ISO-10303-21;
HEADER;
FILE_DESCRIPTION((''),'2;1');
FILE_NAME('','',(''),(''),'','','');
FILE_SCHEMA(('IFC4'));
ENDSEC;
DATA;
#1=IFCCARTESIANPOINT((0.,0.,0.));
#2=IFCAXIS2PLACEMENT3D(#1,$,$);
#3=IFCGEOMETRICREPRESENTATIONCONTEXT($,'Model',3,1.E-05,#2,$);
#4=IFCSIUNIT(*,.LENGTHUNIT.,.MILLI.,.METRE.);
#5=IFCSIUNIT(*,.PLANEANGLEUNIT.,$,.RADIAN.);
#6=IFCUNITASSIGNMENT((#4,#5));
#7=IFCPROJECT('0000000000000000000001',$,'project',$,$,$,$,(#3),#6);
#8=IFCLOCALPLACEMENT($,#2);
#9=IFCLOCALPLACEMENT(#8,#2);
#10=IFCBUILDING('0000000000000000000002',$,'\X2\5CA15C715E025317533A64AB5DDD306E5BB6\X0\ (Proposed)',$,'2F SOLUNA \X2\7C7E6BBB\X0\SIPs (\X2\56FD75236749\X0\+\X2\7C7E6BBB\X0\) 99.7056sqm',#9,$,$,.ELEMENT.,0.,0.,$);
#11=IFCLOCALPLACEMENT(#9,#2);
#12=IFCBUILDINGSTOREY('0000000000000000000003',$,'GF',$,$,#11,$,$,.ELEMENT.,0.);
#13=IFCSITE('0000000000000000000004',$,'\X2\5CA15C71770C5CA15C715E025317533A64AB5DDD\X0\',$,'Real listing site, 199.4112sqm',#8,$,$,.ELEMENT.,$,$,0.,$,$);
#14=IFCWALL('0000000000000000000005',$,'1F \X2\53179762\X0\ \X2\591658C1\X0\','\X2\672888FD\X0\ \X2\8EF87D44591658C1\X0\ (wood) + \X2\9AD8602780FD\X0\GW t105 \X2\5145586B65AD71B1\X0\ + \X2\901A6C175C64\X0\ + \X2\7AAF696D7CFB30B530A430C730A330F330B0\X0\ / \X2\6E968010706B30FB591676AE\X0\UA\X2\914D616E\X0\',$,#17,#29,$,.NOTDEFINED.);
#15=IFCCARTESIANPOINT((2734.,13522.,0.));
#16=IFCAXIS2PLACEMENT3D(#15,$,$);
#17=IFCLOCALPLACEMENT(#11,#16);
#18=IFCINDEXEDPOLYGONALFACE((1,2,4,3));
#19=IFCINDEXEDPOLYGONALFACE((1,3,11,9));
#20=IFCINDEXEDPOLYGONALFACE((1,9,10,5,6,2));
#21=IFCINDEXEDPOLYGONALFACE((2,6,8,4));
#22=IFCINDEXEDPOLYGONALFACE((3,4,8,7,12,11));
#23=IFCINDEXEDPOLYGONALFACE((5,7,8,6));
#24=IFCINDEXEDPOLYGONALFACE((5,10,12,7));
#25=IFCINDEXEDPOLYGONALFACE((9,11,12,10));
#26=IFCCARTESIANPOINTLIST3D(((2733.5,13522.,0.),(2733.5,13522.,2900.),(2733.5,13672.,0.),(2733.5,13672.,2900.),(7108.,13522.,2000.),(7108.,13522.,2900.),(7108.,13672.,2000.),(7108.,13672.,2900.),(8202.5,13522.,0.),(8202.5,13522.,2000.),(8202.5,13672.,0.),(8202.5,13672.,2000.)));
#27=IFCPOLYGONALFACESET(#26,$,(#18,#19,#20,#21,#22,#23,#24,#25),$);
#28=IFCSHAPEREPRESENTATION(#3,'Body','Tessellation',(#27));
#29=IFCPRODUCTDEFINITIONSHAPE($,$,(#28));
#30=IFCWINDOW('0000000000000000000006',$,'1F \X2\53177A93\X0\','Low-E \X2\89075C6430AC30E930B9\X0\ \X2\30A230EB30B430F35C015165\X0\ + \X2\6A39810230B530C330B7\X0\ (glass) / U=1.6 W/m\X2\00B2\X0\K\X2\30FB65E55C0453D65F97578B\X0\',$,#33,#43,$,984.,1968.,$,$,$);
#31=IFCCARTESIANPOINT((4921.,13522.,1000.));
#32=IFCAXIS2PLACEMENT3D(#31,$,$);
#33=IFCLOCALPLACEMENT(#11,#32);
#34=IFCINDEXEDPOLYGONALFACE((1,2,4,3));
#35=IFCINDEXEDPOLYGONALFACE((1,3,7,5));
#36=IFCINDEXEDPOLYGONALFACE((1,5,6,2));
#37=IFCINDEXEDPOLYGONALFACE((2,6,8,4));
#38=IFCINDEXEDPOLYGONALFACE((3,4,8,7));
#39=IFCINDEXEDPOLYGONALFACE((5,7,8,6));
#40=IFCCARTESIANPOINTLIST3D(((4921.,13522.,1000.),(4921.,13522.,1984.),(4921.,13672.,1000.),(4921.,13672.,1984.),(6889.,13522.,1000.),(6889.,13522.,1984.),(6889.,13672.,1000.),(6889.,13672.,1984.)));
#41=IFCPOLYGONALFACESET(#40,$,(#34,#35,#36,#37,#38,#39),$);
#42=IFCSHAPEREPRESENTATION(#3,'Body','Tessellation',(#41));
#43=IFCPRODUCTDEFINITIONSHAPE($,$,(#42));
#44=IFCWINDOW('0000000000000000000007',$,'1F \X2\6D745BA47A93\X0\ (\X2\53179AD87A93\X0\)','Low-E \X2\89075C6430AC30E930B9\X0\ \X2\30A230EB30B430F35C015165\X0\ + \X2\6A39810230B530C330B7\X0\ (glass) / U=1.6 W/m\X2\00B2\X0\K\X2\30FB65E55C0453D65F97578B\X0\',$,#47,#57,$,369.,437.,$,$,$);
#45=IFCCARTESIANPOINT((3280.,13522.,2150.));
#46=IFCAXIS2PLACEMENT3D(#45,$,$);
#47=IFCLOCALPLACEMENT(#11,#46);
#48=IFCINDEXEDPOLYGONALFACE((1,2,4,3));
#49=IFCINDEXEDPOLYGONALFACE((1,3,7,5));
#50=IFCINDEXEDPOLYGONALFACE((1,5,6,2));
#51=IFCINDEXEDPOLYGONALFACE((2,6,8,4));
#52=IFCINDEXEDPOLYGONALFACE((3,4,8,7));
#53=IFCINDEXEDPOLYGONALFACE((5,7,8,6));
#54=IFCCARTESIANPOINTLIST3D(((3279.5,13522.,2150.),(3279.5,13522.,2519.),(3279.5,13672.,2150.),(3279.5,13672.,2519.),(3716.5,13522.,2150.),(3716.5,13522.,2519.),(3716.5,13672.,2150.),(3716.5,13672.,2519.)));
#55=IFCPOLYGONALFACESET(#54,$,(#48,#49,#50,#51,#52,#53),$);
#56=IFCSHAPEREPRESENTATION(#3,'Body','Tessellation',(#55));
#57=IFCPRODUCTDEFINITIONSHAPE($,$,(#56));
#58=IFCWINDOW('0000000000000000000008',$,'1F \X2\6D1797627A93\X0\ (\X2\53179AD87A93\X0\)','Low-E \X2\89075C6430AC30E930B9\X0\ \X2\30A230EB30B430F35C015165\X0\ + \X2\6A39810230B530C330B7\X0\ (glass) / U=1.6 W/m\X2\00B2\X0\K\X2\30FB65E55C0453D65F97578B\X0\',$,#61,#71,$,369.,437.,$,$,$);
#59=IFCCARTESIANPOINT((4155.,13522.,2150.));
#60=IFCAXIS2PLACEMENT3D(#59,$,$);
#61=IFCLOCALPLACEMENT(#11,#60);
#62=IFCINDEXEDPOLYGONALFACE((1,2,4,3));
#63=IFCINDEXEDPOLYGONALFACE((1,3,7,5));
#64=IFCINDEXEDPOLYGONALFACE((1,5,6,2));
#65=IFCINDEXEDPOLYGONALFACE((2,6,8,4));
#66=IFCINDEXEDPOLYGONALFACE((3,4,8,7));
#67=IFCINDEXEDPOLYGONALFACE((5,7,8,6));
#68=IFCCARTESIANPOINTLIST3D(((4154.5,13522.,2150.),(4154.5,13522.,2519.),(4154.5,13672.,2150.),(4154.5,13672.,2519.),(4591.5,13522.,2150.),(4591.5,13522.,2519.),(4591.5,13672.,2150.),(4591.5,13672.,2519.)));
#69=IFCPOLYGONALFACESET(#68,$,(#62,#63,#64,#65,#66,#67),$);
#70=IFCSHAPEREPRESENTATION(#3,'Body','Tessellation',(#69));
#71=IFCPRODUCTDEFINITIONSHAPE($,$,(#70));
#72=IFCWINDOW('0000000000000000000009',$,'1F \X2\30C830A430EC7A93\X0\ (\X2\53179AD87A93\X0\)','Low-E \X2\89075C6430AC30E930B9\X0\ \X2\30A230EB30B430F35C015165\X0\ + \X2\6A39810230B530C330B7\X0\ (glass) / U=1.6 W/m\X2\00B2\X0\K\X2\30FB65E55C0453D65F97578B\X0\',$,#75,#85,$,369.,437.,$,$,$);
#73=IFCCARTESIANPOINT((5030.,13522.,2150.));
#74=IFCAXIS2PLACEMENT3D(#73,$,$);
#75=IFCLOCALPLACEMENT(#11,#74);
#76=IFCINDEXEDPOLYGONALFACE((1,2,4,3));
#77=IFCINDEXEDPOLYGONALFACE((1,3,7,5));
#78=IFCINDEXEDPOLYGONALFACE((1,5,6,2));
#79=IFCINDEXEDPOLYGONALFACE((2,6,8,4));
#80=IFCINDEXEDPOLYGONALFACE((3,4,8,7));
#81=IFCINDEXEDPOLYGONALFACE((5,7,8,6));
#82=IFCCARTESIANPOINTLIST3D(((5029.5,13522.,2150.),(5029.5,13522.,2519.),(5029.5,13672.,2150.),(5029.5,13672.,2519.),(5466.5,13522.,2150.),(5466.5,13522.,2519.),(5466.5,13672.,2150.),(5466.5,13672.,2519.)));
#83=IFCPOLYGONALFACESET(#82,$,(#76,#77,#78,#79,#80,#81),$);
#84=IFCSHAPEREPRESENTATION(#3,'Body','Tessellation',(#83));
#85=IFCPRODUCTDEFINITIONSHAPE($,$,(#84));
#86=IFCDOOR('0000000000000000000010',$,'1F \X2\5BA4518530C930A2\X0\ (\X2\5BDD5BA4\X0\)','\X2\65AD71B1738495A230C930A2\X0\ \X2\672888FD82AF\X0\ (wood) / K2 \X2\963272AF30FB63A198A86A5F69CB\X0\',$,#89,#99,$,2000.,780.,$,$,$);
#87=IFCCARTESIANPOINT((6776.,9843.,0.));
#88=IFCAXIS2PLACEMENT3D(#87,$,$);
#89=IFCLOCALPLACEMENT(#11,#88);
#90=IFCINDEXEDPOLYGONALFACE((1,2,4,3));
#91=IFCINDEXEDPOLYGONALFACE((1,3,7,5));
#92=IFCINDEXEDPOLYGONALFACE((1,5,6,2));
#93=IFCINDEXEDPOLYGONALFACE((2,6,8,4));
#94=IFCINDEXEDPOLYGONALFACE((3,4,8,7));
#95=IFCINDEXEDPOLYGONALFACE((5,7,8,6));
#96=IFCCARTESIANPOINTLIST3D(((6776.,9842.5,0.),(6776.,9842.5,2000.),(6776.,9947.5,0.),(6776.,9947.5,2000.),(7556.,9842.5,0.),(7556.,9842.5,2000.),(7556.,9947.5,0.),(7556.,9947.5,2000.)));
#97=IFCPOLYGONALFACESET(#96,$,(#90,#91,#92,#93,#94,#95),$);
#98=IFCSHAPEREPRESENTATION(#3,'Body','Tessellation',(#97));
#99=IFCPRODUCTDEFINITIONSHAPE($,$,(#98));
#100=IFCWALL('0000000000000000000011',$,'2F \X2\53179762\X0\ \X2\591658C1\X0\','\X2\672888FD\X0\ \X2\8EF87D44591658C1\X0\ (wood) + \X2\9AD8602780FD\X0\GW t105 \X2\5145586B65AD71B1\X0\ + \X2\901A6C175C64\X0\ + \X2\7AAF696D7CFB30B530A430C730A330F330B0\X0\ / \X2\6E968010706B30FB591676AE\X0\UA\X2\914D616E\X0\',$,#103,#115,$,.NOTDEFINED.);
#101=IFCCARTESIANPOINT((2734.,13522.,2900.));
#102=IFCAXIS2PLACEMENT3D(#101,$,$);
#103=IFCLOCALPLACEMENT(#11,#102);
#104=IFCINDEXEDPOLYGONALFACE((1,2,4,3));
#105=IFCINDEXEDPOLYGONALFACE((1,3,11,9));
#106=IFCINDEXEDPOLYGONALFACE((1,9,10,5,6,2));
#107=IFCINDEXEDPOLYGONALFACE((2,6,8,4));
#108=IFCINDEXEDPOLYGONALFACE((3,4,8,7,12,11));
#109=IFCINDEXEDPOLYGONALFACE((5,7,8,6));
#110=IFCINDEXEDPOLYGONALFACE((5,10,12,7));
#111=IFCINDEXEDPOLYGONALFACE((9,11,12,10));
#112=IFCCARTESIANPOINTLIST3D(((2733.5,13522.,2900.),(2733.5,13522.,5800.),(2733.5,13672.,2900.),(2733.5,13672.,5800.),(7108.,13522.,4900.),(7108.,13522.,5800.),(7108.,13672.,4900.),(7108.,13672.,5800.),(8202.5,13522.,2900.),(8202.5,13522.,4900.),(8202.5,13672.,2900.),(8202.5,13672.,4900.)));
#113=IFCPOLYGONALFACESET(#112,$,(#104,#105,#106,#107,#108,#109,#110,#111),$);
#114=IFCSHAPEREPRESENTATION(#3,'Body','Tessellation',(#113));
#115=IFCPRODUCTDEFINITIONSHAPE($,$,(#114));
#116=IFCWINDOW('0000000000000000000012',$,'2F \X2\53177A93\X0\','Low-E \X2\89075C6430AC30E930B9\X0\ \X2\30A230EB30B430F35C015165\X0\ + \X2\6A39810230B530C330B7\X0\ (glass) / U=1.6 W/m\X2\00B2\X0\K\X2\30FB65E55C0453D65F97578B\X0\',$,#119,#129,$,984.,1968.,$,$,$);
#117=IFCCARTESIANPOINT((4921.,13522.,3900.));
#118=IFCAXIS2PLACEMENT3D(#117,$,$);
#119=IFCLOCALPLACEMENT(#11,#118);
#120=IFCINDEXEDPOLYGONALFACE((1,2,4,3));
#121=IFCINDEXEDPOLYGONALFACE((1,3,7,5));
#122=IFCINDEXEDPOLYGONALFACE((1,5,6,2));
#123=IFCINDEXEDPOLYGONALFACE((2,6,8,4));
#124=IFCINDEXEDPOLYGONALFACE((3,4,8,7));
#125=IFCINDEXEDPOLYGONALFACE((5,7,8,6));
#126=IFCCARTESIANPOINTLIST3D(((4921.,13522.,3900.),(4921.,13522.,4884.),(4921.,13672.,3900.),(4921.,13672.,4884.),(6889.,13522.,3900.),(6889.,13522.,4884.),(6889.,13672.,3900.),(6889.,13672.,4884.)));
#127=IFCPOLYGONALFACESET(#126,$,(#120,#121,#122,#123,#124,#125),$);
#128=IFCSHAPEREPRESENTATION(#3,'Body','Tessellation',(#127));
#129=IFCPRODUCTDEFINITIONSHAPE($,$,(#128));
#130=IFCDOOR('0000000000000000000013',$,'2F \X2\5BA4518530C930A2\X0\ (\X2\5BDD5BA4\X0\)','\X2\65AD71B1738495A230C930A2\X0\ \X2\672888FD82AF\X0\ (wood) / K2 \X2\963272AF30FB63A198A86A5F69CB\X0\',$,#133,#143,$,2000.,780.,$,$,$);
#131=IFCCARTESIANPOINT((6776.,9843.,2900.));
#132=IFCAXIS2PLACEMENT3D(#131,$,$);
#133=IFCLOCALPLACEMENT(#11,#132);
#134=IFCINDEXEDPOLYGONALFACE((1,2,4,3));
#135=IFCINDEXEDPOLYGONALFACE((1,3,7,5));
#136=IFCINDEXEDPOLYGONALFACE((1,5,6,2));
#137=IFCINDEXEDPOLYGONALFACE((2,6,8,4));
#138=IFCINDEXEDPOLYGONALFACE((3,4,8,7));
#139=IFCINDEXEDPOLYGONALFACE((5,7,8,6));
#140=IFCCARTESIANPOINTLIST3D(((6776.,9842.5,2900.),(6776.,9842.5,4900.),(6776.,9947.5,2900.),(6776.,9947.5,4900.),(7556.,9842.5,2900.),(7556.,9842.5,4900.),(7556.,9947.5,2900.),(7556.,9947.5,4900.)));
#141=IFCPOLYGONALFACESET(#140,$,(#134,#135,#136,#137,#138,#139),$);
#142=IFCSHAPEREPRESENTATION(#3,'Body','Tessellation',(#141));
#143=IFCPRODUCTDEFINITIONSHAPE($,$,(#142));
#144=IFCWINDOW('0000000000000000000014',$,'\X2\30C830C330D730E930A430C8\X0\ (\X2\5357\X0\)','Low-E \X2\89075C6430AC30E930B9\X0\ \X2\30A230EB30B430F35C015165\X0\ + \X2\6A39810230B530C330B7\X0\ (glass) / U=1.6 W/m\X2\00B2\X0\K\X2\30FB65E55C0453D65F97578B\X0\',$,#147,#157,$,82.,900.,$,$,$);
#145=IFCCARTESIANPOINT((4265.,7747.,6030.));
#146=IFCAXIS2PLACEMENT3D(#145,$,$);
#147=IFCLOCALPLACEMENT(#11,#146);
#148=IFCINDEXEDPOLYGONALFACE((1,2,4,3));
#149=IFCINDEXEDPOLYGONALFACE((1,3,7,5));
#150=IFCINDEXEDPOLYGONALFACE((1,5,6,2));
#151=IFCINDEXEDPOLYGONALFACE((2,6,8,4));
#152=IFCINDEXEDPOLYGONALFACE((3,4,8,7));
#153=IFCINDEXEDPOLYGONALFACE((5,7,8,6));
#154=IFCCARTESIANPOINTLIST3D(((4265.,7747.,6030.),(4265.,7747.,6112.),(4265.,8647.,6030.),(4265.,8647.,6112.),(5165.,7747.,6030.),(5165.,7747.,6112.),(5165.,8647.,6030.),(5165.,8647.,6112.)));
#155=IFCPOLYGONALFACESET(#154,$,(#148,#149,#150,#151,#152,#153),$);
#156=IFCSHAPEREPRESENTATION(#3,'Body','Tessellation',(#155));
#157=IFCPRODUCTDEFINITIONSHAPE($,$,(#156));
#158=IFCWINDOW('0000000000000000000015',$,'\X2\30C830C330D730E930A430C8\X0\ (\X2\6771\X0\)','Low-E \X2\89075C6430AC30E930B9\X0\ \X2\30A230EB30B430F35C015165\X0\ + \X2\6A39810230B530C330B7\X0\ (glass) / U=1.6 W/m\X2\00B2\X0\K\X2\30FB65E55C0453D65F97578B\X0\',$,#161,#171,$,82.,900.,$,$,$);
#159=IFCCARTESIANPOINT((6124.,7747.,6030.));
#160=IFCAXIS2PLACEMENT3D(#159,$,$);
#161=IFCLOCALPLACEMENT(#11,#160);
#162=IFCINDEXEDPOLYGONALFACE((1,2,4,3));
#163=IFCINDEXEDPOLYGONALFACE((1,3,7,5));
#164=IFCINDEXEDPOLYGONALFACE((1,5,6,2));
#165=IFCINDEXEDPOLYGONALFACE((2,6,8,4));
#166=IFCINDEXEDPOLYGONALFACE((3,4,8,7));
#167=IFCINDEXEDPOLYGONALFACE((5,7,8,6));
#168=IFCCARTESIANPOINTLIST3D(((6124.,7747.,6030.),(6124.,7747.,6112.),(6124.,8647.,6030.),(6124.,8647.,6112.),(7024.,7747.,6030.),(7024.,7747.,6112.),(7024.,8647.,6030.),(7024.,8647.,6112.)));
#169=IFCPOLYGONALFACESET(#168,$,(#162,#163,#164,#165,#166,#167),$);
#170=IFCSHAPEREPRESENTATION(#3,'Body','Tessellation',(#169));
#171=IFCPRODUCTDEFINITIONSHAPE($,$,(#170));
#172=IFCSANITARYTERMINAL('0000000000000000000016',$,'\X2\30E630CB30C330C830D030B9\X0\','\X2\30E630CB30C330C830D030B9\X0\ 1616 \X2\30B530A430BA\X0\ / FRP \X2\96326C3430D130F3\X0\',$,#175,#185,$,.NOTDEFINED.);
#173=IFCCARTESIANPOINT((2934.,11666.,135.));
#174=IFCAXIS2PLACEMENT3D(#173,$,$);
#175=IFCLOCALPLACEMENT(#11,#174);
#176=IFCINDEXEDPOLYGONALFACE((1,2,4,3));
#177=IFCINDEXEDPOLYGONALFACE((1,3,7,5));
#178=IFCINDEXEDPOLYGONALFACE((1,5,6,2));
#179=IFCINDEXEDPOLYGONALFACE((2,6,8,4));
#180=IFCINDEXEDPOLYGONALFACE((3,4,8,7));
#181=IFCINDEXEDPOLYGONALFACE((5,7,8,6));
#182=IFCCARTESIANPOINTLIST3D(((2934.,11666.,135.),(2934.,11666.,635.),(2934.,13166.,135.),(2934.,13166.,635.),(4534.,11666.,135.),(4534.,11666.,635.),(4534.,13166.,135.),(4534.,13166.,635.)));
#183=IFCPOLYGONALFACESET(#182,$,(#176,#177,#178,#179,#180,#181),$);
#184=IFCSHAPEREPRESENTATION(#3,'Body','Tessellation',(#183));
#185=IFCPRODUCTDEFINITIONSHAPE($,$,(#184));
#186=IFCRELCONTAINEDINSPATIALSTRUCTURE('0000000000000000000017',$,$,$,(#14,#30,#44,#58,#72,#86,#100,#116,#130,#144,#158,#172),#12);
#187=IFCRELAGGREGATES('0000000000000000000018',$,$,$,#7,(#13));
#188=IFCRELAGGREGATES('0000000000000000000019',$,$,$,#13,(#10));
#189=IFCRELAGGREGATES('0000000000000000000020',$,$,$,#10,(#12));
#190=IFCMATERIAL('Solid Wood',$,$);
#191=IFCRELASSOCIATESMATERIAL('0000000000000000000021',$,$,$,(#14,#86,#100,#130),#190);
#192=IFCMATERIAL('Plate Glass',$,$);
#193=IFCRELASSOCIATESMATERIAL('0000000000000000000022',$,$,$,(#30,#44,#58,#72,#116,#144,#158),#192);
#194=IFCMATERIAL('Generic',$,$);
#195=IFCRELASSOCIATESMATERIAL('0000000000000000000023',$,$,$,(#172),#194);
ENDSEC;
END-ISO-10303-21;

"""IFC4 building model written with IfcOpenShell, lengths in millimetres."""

from ifc_helpers import new_model, si_unit, frame, frame_2d, origin, place, context, project, spatial, rectangle, extrude, material, element, fill, save


model = new_model("IFC4")

# Units and contexts
model_context = context("Model", 3, precision=1e-05, world=origin())
ifc_project = project(units=[si_unit("LENGTHUNIT", "METRE", prefix="MILLI"), si_unit("PLANEANGLEUNIT", "RADIAN")], contexts=[model_context])

# Site, building, storey
site_placement = place(None, origin())
site = spatial("IfcSite", under=ifc_project, at=site_placement, Name="岡山県岡山市北区撫川", ObjectType="Real listing site, 199.4112sqm", CompositionType="ELEMENT", RefElevation=0.0)
building_placement = place(site_placement, origin())
building = spatial("IfcBuilding", under=site, at=building_placement, Name="岡山市北区撫川の家 (Proposed)", ObjectType="2F SOLUNA 籾殻SIPs (国産杉+籾殻) 99.7056sqm", CompositionType="ELEMENT", ElevationOfRefHeight=0.0, ElevationOfTerrain=0.0)
storey_placement = place(building_placement, origin())
storey = spatial("IfcBuildingStorey", under=building, at=storey_placement, Name="GF", CompositionType="ELEMENT", Elevation=0.0)

# Wall, openings, windows
ifc_material_1 = material(Name="Solid Wood")
wall_1_placement = place(storey_placement, frame((2734.0, 13522.0, 0.0)))
wall_1 = element("IfcWall", 1, at=wall_1_placement, inside=storey, material=ifc_material_1, Name="1F 北面 外壁", Description="木製 軸組外壁 (wood) + 高性能GW t105 充填断熱 + 通気層 + 窯業系サイディング / 準耐火・外皮UA配慮", PredefinedType="NOTDEFINED", context=model_context, shape_type="SweptSolid", body=[
    extrude(rectangle(XDim=5469.0, YDim=150.0, at=frame_2d((2734.0, 75.0))), frame((2734.0, 13522.0, 0.0)), (0.0, 0.0, 1.0), 2900.0),
])
opening_1_placement = place(storey_placement, frame((4921.0, 13522.0, 1000.0)))
opening_1 = element("IfcOpeningElement", 2, at=opening_1_placement, cuts=wall_1, PredefinedType="NOTDEFINED", context=model_context, shape_type="SweptSolid", body=[
    extrude(rectangle(XDim=1968.0, YDim=150.0, at=frame_2d((984.0, 75.0))), frame((4921.0, 13522.0, 1000.0)), (0.0, 0.0, 1.0), 984.0),
])
opening_2_placement = place(storey_placement, frame((3280.0, 13522.0, 2150.0)))
opening_2 = element("IfcOpeningElement", 3, at=opening_2_placement, cuts=wall_1, PredefinedType="NOTDEFINED", context=model_context, shape_type="SweptSolid", body=[
    extrude(rectangle(XDim=437.0, YDim=150.0, at=frame_2d((218.0, 75.0))), frame((3280.0, 13522.0, 2150.0)), (0.0, 0.0, 1.0), 369.0),
])
opening_3_placement = place(storey_placement, frame((4155.0, 13522.0, 2150.0)))
opening_3 = element("IfcOpeningElement", 4, at=opening_3_placement, cuts=wall_1, PredefinedType="NOTDEFINED", context=model_context, shape_type="SweptSolid", body=[
    extrude(rectangle(XDim=437.0, YDim=150.0, at=frame_2d((218.0, 75.0))), frame((4155.0, 13522.0, 2150.0)), (0.0, 0.0, 1.0), 369.0),
])
opening_4_placement = place(storey_placement, frame((5030.0, 13522.0, 2150.0)))
opening_4 = element("IfcOpeningElement", 5, at=opening_4_placement, cuts=wall_1, PredefinedType="NOTDEFINED", context=model_context, shape_type="SweptSolid", body=[
    extrude(rectangle(XDim=437.0, YDim=150.0, at=frame_2d((218.0, 75.0))), frame((5030.0, 13522.0, 2150.0)), (0.0, 0.0, 1.0), 369.0),
])
ifc_material_2 = material(Name="Plate Glass")
window_1_placement = place(storey_placement, frame((4921.0, 13522.0, 1000.0)))
window_1 = element("IfcWindow", 6, at=window_1_placement, inside=storey, material=ifc_material_2, Name="1F 北窓", Description="Low-E 複層ガラス アルゴン封入 + 樹脂サッシ (glass) / U=1.6 W/m²K・日射取得型", OverallHeight=984.0, OverallWidth=1968.0, context=model_context, shape_type="SweptSolid", body=[
    extrude(rectangle(XDim=1968.0, YDim=150.0, at=frame_2d((984.0, 75.0))), frame((4921.0, 13522.0, 1000.0)), (0.0, 0.0, 1.0), 984.0),
])
fill(opening_1, window_1)
window_2_placement = place(storey_placement, frame((3280.0, 13522.0, 2150.0)))
window_2 = element("IfcWindow", 7, at=window_2_placement, inside=storey, material=ifc_material_2, Name="1F 浴室窓 (北高窓)", Description="Low-E 複層ガラス アルゴン封入 + 樹脂サッシ (glass) / U=1.6 W/m²K・日射取得型", OverallHeight=369.0, OverallWidth=437.0, context=model_context, shape_type="SweptSolid", body=[
    extrude(rectangle(XDim=437.0, YDim=150.0, at=frame_2d((218.0, 75.0))), frame((3280.0, 13522.0, 2150.0)), (0.0, 0.0, 1.0), 369.0),
])
fill(opening_2, window_2)
window_3_placement = place(storey_placement, frame((4155.0, 13522.0, 2150.0)))
window_3 = element("IfcWindow", 8, at=window_3_placement, inside=storey, material=ifc_material_2, Name="1F 洗面窓 (北高窓)", Description="Low-E 複層ガラス アルゴン封入 + 樹脂サッシ (glass) / U=1.6 W/m²K・日射取得型", OverallHeight=369.0, OverallWidth=437.0, context=model_context, shape_type="SweptSolid", body=[
    extrude(rectangle(XDim=437.0, YDim=150.0, at=frame_2d((218.0, 75.0))), frame((4155.0, 13522.0, 2150.0)), (0.0, 0.0, 1.0), 369.0),
])
fill(opening_3, window_3)
window_4_placement = place(storey_placement, frame((5030.0, 13522.0, 2150.0)))
window_4 = element("IfcWindow", 9, at=window_4_placement, inside=storey, material=ifc_material_2, Name="1F トイレ窓 (北高窓)", Description="Low-E 複層ガラス アルゴン封入 + 樹脂サッシ (glass) / U=1.6 W/m²K・日射取得型", OverallHeight=369.0, OverallWidth=437.0, context=model_context, shape_type="SweptSolid", body=[
    extrude(rectangle(XDim=437.0, YDim=150.0, at=frame_2d((218.0, 75.0))), frame((5030.0, 13522.0, 2150.0)), (0.0, 0.0, 1.0), 369.0),
])
fill(opening_4, window_4)

# Door
door_1_placement = place(storey_placement, frame((6776.0, 9843.0, 0.0)))
element("IfcDoor", 10, at=door_1_placement, inside=storey, material=ifc_material_1, Name="1F 室内ドア (寝室)", Description="断熱玄関ドア 木製芯 (wood) / K2 防犯・採風機構", OverallHeight=2000.0, OverallWidth=780.0, context=model_context, shape_type="SweptSolid", body=[
    extrude(rectangle(XDim=780.0, YDim=105.0, at=frame_2d((390.0, 52.0))), frame((6776.0, 9843.0, 0.0)), (0.0, 0.0, 1.0), 2000.0),
])

# Wall, opening, window
wall_2_placement = place(storey_placement, frame((2734.0, 13522.0, 2900.0)))
wall_2 = element("IfcWall", 11, at=wall_2_placement, inside=storey, material=ifc_material_1, Name="2F 北面 外壁", Description="木製 軸組外壁 (wood) + 高性能GW t105 充填断熱 + 通気層 + 窯業系サイディング / 準耐火・外皮UA配慮", PredefinedType="NOTDEFINED", context=model_context, shape_type="SweptSolid", body=[
    extrude(rectangle(XDim=5469.0, YDim=150.0, at=frame_2d((2734.0, 75.0))), frame((2734.0, 13522.0, 2900.0)), (0.0, 0.0, 1.0), 2900.0),
])
opening_5_placement = place(storey_placement, frame((4921.0, 13522.0, 3900.0)))
opening_5 = element("IfcOpeningElement", 12, at=opening_5_placement, cuts=wall_2, PredefinedType="NOTDEFINED", context=model_context, shape_type="SweptSolid", body=[
    extrude(rectangle(XDim=1968.0, YDim=150.0, at=frame_2d((984.0, 75.0))), frame((4921.0, 13522.0, 3900.0)), (0.0, 0.0, 1.0), 984.0),
])
window_5_placement = place(storey_placement, frame((4921.0, 13522.0, 3900.0)))
window_5 = element("IfcWindow", 13, at=window_5_placement, inside=storey, material=ifc_material_2, Name="2F 北窓", Description="Low-E 複層ガラス アルゴン封入 + 樹脂サッシ (glass) / U=1.6 W/m²K・日射取得型", OverallHeight=984.0, OverallWidth=1968.0, context=model_context, shape_type="SweptSolid", body=[
    extrude(rectangle(XDim=1968.0, YDim=150.0, at=frame_2d((984.0, 75.0))), frame((4921.0, 13522.0, 3900.0)), (0.0, 0.0, 1.0), 984.0),
])
fill(opening_5, window_5)

# Door
door_2_placement = place(storey_placement, frame((6776.0, 9843.0, 2900.0)))
element("IfcDoor", 14, at=door_2_placement, inside=storey, material=ifc_material_1, Name="2F 室内ドア (寝室)", Description="断熱玄関ドア 木製芯 (wood) / K2 防犯・採風機構", OverallHeight=2000.0, OverallWidth=780.0, context=model_context, shape_type="SweptSolid", body=[
    extrude(rectangle(XDim=780.0, YDim=105.0, at=frame_2d((390.0, 52.0))), frame((6776.0, 9843.0, 2900.0)), (0.0, 0.0, 1.0), 2000.0),
])

# Windows
window_6_placement = place(storey_placement, frame((4265.0, 7747.0, 6030.0)))
element("IfcWindow", 15, at=window_6_placement, inside=storey, material=ifc_material_2, Name="トップライト (南)", Description="Low-E 複層ガラス アルゴン封入 + 樹脂サッシ (glass) / U=1.6 W/m²K・日射取得型", OverallHeight=82.0, OverallWidth=900.0, context=model_context, shape_type="SweptSolid", body=[
    extrude(rectangle(XDim=900.0, YDim=900.0, at=frame_2d((450.0, 450.0))), frame((4265.0, 7747.0, 6030.0)), (0.0, 0.0, 1.0), 82.0),
])
window_7_placement = place(storey_placement, frame((6124.0, 7747.0, 6030.0)))
element("IfcWindow", 16, at=window_7_placement, inside=storey, material=ifc_material_2, Name="トップライト (東)", Description="Low-E 複層ガラス アルゴン封入 + 樹脂サッシ (glass) / U=1.6 W/m²K・日射取得型", OverallHeight=82.0, OverallWidth=900.0, context=model_context, shape_type="SweptSolid", body=[
    extrude(rectangle(XDim=900.0, YDim=900.0, at=frame_2d((450.0, 450.0))), frame((6124.0, 7747.0, 6030.0)), (0.0, 0.0, 1.0), 82.0),
])

# Sanitary terminal
ifc_material_3 = material(Name="Generic")
sanitary_terminal_1_placement = place(storey_placement, frame((2934.0, 11666.0, 135.0)))
element("IfcSanitaryTerminal", 17, at=sanitary_terminal_1_placement, inside=storey, material=ifc_material_3, Name="ユニットバス", Description="ユニットバス 1616 サイズ / FRP 防水パン", PredefinedType="NOTDEFINED", context=model_context, shape_type="SweptSolid", body=[
    extrude(rectangle(XDim=1600.0, YDim=1500.0, at=frame_2d((800.0, 750.0))), frame((2934.0, 11666.0, 135.0)), (0.0, 0.0, 1.0), 500.0),
])

save(model, "model.ifc")
